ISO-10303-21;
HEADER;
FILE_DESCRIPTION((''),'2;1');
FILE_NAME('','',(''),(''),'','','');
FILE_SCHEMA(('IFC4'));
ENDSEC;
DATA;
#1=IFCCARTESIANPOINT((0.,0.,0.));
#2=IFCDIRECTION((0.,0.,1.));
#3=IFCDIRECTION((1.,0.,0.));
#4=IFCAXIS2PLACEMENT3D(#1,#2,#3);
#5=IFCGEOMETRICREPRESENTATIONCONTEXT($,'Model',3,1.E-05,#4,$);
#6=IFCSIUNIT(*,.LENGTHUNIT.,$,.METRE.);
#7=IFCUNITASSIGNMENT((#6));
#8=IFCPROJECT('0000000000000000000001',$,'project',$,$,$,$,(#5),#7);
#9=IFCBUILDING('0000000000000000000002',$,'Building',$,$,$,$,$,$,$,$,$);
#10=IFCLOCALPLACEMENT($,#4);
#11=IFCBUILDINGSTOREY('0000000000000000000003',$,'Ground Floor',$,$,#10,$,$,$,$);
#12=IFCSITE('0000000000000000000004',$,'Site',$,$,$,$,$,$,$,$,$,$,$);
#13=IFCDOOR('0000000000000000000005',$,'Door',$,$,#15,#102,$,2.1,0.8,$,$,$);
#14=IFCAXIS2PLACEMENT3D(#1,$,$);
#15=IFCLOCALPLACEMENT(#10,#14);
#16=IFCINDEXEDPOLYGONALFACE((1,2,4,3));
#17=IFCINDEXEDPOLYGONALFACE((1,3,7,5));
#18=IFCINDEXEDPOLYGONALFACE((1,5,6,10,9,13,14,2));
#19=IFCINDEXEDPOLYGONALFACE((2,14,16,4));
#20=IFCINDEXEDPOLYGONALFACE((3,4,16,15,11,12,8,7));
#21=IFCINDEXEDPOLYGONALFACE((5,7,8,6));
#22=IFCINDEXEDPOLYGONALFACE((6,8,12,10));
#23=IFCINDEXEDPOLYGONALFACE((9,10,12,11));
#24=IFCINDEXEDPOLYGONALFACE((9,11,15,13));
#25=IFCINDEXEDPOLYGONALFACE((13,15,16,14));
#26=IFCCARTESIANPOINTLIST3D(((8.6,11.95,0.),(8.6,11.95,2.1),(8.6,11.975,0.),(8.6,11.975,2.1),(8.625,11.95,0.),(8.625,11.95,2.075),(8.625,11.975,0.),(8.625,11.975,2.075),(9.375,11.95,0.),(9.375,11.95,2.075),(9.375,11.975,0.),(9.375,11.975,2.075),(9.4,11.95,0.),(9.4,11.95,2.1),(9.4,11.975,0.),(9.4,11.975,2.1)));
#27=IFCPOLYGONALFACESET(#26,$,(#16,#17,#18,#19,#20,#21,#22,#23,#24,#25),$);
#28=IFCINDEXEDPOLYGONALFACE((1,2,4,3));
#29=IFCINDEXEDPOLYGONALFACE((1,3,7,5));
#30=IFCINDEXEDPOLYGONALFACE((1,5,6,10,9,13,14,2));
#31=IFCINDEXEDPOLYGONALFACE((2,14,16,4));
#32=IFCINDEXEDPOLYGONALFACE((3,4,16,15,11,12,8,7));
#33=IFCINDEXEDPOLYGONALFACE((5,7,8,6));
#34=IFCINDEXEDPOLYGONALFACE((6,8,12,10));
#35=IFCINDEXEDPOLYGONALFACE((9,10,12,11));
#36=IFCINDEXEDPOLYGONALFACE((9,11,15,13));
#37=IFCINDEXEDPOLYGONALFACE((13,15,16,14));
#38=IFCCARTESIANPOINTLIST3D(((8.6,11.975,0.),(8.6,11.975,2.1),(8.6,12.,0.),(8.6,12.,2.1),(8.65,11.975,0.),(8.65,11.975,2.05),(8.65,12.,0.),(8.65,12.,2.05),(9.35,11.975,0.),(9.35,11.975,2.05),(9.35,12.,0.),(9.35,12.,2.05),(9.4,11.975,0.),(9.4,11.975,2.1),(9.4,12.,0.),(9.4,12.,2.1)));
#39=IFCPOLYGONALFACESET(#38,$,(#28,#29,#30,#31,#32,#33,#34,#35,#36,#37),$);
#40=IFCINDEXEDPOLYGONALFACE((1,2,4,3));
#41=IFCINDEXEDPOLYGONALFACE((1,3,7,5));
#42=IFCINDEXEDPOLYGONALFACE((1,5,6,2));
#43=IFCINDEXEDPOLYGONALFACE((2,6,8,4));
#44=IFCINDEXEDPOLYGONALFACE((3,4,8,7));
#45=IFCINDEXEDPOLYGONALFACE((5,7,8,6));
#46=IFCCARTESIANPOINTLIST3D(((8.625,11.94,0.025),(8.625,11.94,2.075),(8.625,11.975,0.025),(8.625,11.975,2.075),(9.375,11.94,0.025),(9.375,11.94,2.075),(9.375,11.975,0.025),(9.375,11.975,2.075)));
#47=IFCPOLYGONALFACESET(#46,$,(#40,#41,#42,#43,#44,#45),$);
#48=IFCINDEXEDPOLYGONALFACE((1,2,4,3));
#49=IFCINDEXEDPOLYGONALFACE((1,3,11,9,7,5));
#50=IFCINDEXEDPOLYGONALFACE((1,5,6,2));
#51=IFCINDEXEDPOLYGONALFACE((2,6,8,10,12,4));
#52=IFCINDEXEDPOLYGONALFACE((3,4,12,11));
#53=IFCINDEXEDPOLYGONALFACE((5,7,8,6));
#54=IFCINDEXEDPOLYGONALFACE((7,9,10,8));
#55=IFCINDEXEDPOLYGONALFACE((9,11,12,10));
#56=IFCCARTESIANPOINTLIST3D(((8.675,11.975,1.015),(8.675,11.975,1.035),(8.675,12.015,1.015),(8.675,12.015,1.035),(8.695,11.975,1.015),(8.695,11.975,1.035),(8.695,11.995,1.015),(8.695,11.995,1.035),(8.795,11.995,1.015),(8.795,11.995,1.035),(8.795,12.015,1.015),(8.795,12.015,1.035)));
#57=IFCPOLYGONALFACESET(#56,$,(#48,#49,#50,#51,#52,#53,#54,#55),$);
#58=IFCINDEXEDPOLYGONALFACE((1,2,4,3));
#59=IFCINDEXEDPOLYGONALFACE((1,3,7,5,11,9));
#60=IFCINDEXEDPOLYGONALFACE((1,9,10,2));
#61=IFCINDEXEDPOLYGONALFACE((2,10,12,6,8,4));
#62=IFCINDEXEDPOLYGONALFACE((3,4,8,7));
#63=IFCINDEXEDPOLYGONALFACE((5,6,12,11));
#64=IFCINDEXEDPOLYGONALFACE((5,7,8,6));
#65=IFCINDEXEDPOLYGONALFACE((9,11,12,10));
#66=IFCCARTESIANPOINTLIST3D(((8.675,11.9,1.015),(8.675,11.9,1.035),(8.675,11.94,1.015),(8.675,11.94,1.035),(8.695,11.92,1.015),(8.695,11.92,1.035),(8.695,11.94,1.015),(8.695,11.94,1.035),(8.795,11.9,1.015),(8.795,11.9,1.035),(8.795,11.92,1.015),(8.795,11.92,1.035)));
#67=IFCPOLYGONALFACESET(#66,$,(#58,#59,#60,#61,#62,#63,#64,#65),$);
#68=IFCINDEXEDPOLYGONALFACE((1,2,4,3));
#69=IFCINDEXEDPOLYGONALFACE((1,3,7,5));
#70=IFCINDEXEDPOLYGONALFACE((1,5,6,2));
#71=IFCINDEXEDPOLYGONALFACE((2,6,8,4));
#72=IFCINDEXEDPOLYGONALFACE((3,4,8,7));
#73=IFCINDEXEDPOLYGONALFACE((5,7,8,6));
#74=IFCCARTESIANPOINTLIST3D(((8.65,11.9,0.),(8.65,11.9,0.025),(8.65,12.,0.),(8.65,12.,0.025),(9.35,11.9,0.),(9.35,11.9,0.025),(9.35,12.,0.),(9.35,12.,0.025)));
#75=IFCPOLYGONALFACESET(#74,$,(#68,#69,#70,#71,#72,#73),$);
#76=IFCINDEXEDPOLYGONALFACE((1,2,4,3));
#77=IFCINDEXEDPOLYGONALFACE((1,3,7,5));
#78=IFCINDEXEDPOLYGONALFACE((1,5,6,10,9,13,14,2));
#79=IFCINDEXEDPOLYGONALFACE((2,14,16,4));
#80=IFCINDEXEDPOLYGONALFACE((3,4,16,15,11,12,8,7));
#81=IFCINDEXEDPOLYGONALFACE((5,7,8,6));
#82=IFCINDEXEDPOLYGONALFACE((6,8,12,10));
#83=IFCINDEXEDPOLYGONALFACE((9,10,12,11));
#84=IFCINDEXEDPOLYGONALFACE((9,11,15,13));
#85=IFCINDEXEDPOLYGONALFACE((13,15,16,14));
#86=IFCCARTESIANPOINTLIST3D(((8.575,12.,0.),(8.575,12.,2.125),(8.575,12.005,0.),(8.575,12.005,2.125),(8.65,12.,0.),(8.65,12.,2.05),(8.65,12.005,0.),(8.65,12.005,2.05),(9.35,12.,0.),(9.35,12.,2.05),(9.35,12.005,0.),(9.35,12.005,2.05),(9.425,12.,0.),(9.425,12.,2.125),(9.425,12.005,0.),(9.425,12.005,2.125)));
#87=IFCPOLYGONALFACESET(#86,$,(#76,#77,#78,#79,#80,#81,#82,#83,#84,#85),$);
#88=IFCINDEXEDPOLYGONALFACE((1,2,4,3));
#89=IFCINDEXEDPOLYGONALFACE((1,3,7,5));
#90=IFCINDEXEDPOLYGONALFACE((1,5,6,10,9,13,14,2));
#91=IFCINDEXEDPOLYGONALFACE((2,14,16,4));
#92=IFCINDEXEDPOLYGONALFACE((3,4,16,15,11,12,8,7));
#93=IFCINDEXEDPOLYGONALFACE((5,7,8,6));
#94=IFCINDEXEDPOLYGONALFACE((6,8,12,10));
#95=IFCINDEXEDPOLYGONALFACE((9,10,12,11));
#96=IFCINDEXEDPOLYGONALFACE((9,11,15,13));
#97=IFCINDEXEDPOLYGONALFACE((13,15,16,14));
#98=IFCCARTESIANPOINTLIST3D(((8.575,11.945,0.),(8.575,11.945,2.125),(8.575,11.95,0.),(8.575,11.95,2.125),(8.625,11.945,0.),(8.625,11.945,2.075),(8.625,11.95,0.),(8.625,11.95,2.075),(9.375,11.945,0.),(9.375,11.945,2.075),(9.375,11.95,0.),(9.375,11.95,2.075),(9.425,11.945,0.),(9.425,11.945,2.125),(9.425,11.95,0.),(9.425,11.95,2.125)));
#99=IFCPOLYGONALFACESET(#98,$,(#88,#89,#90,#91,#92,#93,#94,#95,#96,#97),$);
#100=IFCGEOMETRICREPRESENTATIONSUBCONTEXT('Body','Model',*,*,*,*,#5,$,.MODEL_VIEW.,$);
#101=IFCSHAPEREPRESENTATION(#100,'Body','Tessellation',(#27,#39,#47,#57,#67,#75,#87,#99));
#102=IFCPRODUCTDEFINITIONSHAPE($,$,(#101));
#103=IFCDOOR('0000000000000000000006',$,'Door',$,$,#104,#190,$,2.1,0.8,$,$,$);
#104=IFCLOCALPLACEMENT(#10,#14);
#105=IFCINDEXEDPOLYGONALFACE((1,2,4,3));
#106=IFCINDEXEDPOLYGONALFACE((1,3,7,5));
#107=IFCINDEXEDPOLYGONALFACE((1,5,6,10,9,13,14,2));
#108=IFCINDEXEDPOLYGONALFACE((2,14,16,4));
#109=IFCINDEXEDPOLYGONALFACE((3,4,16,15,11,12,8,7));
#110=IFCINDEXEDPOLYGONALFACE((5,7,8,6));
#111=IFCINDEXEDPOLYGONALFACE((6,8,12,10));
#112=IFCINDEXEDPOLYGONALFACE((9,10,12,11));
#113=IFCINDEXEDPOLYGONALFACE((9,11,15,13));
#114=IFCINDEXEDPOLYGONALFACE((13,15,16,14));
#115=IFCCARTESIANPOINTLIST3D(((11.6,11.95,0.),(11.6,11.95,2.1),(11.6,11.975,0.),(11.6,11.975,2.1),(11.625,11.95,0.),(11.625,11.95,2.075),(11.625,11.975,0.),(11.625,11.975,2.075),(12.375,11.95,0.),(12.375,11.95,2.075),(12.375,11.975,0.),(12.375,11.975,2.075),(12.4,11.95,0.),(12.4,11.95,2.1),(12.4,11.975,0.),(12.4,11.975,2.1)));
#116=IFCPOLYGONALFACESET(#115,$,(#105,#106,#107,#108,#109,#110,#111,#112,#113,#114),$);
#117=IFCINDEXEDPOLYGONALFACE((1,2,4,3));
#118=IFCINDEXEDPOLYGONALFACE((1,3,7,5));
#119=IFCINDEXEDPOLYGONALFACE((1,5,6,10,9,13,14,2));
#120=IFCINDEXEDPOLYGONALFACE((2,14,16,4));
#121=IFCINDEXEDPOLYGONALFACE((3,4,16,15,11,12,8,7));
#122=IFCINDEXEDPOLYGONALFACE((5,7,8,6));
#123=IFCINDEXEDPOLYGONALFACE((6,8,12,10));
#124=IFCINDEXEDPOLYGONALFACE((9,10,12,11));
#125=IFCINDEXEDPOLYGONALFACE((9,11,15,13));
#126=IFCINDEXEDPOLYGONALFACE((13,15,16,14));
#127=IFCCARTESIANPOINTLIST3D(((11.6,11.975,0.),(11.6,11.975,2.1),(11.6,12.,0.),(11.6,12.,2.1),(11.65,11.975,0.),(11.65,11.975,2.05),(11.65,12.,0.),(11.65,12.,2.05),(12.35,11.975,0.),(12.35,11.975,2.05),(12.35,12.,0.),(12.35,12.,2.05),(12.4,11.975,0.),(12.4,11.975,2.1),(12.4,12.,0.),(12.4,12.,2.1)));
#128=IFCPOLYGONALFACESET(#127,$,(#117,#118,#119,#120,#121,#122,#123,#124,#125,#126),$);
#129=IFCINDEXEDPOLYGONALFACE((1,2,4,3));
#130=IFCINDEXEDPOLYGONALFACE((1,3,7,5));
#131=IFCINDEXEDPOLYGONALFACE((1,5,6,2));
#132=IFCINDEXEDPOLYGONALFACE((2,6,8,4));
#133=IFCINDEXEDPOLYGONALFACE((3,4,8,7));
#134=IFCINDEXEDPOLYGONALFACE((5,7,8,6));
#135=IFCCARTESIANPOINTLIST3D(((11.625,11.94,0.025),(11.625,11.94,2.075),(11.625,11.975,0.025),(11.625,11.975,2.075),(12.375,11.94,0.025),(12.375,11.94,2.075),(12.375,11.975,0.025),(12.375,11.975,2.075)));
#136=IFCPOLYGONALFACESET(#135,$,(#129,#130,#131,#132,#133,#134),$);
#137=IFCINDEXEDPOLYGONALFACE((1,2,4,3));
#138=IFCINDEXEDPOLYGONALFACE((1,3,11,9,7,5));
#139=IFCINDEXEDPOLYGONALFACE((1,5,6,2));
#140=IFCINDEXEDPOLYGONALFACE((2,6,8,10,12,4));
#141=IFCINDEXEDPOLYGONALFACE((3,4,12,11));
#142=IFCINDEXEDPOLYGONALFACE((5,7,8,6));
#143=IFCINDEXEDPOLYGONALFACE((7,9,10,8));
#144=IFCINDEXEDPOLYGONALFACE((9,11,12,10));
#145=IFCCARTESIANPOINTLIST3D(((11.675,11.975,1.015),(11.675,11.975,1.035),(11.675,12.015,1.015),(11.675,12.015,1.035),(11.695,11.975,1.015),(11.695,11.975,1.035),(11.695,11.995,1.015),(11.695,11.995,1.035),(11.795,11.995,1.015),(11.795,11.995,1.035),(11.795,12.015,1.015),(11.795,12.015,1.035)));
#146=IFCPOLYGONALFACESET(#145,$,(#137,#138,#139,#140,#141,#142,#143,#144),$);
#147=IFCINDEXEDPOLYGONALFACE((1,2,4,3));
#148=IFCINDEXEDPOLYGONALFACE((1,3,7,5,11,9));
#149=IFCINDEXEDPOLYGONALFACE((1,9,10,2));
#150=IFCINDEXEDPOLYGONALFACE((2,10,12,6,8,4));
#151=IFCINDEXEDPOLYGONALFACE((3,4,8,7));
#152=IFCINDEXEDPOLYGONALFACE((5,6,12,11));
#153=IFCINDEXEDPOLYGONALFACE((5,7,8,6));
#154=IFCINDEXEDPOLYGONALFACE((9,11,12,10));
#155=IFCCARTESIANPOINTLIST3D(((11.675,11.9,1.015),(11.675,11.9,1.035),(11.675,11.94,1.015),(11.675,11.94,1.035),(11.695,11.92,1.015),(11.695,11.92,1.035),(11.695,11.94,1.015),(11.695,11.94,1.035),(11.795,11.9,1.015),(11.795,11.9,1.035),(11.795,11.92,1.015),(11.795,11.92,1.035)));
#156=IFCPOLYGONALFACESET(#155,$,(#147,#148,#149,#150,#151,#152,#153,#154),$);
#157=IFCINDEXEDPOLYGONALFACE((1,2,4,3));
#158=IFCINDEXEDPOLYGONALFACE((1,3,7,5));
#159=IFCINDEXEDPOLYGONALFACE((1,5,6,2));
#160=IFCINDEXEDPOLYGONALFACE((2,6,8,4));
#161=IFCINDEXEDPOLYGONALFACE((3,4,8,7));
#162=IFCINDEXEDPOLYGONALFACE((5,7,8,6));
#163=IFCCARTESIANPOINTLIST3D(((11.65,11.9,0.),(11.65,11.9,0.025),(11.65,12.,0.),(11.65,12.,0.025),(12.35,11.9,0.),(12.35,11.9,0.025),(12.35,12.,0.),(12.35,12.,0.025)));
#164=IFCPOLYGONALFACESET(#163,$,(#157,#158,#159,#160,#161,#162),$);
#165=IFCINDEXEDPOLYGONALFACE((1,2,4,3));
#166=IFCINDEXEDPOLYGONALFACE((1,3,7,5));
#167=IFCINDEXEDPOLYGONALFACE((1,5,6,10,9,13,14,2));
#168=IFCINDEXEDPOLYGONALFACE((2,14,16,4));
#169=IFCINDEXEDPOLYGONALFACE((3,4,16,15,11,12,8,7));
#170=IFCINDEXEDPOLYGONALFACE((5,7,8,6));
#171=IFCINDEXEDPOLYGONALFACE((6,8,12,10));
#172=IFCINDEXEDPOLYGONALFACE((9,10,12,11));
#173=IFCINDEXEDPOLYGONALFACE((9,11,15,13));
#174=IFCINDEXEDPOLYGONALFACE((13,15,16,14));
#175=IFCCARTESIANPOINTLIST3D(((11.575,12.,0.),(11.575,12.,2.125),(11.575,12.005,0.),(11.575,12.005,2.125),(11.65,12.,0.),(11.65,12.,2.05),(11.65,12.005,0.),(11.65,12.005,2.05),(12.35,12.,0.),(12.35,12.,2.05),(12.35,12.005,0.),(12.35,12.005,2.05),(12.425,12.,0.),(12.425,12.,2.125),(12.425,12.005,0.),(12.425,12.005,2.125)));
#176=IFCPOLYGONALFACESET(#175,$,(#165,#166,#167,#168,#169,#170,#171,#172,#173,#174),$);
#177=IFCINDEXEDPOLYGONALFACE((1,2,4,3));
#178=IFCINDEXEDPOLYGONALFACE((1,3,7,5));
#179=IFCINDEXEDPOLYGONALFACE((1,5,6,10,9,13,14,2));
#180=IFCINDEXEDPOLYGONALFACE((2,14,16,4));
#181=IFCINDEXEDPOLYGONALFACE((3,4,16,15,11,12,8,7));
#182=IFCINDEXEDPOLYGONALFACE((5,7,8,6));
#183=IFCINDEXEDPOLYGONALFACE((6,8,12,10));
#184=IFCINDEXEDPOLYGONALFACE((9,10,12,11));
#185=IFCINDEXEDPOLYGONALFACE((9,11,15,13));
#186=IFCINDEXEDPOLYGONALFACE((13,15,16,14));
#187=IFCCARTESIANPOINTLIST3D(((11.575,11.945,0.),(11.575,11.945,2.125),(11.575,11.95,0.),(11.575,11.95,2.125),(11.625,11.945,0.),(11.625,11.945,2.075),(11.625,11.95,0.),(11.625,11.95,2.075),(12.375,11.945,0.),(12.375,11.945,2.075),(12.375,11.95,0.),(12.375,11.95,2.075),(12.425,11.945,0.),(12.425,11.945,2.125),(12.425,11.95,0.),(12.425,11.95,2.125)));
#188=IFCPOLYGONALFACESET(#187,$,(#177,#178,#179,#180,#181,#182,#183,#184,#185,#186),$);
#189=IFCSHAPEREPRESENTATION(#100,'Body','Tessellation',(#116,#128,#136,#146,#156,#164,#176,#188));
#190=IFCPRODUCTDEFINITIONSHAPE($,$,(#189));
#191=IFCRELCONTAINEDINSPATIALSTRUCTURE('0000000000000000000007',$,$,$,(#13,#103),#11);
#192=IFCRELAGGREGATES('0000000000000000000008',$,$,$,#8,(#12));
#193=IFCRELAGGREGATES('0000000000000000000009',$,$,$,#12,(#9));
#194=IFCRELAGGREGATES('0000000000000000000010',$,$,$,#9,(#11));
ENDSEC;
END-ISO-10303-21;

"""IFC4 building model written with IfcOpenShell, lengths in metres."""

from ifc_helpers import new_model, si_unit, frame, origin_with_axes, place, context, subcontext, project, spatial, line, indexed_curve, outline, extrude, element, save


model = new_model("IFC4")

# Units and contexts
model_context = context("Model", 3, precision=1e-05, world=origin_with_axes())
body_context = subcontext(model_context, "Body", "Model", "MODEL_VIEW")
ifc_project = project(units=[si_unit("LENGTHUNIT", "METRE")], contexts=[model_context])

# Site, building, storey
site = spatial("IfcSite", under=ifc_project, Name="Site")
building = spatial("IfcBuilding", under=site, Name="Building")
storey_placement = place(None, origin_with_axes())
storey = spatial("IfcBuildingStorey", under=building, at=storey_placement, Name="Ground Floor")

# Doors
door_1_placement = place(storey_placement, frame((9.4, 12.0, 0.0), z_axis=(0.0, 0.0, 1.0), x_axis=(-1.0, 0.0, 0.0)))
element("IfcDoor", 1, at=door_1_placement, inside=storey, Name="Door", OverallHeight=2.1, OverallWidth=0.8, context=body_context, shape_type="SweptSolid", body=[
    extrude(outline(indexed_curve([(0.0, 0.0), (0.0, 2.1), (0.8, 2.1), (0.8, 0.0), (0.775, 0.0), (0.775, 2.075), (0.025, 2.075), (0.025, 0.0)], segments=[line(1, 2, 3, 4, 5, 6, 7, 8, 1)])), frame((0.0, 0.025, 0.0), z_axis=(0.0, -1.0, 0.0), x_axis=(1.0, 0.0, 0.0)), (0.0, 0.0, -1.0), 0.025),
    extrude(outline(indexed_curve([(0.0, 0.0), (0.0, 2.1), (0.8, 2.1), (0.8, 0.0), (0.75, 0.0), (0.75, 2.05), (0.05, 2.05), (0.05, 0.0)], segments=[line(1, 2, 3, 4, 5, 6, 7, 8, 1)])), frame((0.0, 0.0, 0.0), z_axis=(0.0, -1.0, 0.0), x_axis=(1.0, 0.0, 0.0)), (0.0, 0.0, -1.0), 0.025),
    extrude(outline(indexed_curve([(0.0, 0.0), (0.75, 0.0), (0.75, 0.035), (0.0, 0.035)], segments=[line(1, 2, 3, 4, 1)])), frame((0.025, 0.025, 0.025), z_axis=(0.0, 0.0, 1.0), x_axis=(1.0, 0.0, 0.0)), (0.0, 0.0, 1.0), 2.05),
    extrude(outline(indexed_curve([(0.0, 0.0), (0.0, -0.04), (-0.12, -0.04), (-0.12, -0.02), (-0.02, -0.02), (-0.02, 0.0)], segments=[line(1, 2, 3, 4, 5, 6, 1)])), frame((0.725, 0.025, 1.015), z_axis=(0.0, 0.0, 1.0), x_axis=(1.0, 0.0, 0.0)), (0.0, 0.0, 1.0), 0.02),
    extrude(outline(indexed_curve([(0.0, 0.0), (0.0, 0.04), (-0.12, 0.04), (-0.12, 0.02), (-0.02, 0.02), (-0.02, 0.0)], segments=[line(1, 2, 3, 4, 5, 6, 1)])), frame((0.725, 0.06, 1.015), z_axis=(0.0, 0.0, 1.0), x_axis=(1.0, 0.0, 0.0)), (0.0, 0.0, 1.0), 0.02),
    extrude(outline(indexed_curve([(0.0, 0.0), (0.7, 0.0), (0.7, 0.1), (0.0, 0.1)], segments=[line(1, 2, 3, 4, 1)])), frame((0.05, 0.0, 0.0), z_axis=(0.0, 0.0, 1.0), x_axis=(1.0, 0.0, 0.0)), (0.0, 0.0, 1.0), 0.025),
    extrude(outline(indexed_curve([(0.0, 0.0), (0.0, 2.125), (0.85, 2.125), (0.85, 0.0), (0.775, 0.0), (0.775, 2.05), (0.075, 2.05), (0.075, 0.0)], segments=[line(1, 2, 3, 4, 5, 6, 7, 8, 1)])), frame((-0.025, -0.005, 0.0), z_axis=(0.0, -1.0, 0.0), x_axis=(1.0, 0.0, 0.0)), (0.0, 0.0, -1.0), 0.005),
    extrude(outline(indexed_curve([(0.0, 0.0), (0.0, 2.125), (0.85, 2.125), (0.85, 0.0), (0.8, 0.0), (0.8, 2.075), (0.05, 2.075), (0.05, 0.0)], segments=[line(1, 2, 3, 4, 5, 6, 7, 8, 1)])), frame((-0.025, 0.05, 0.0), z_axis=(0.0, -1.0, 0.0), x_axis=(1.0, 0.0, 0.0)), (0.0, 0.0, -1.0), 0.005),
])
door_2_placement = place(storey_placement, frame((12.4, 12.0, 0.0), z_axis=(0.0, 0.0, 1.0), x_axis=(-1.0, 0.0, 0.0)))
element("IfcDoor", 2, at=door_2_placement, inside=storey, Name="Door", OverallHeight=2.1, OverallWidth=0.8, context=body_context, shape_type="SweptSolid", body=[
    extrude(outline(indexed_curve([(0.0, 0.0), (0.0, 2.1), (0.8, 2.1), (0.8, 0.0), (0.775, 0.0), (0.775, 2.075), (0.025, 2.075), (0.025, 0.0)], segments=[line(1, 2, 3, 4, 5, 6, 7, 8, 1)])), frame((0.0, 0.025, 0.0), z_axis=(0.0, -1.0, 0.0), x_axis=(1.0, 0.0, 0.0)), (0.0, 0.0, -1.0), 0.025),
    extrude(outline(indexed_curve([(0.0, 0.0), (0.0, 2.1), (0.8, 2.1), (0.8, 0.0), (0.75, 0.0), (0.75, 2.05), (0.05, 2.05), (0.05, 0.0)], segments=[line(1, 2, 3, 4, 5, 6, 7, 8, 1)])), frame((0.0, 0.0, 0.0), z_axis=(0.0, -1.0, 0.0), x_axis=(1.0, 0.0, 0.0)), (0.0, 0.0, -1.0), 0.025),
    extrude(outline(indexed_curve([(0.0, 0.0), (0.75, 0.0), (0.75, 0.035), (0.0, 0.035)], segments=[line(1, 2, 3, 4, 1)])), frame((0.025, 0.025, 0.025), z_axis=(0.0, 0.0, 1.0), x_axis=(1.0, 0.0, 0.0)), (0.0, 0.0, 1.0), 2.05),
    extrude(outline(indexed_curve([(0.0, 0.0), (0.0, -0.04), (-0.12, -0.04), (-0.12, -0.02), (-0.02, -0.02), (-0.02, 0.0)], segments=[line(1, 2, 3, 4, 5, 6, 1)])), frame((0.725, 0.025, 1.015), z_axis=(0.0, 0.0, 1.0), x_axis=(1.0, 0.0, 0.0)), (0.0, 0.0, 1.0), 0.02),
    extrude(outline(indexed_curve([(0.0, 0.0), (0.0, 0.04), (-0.12, 0.04), (-0.12, 0.02), (-0.02, 0.02), (-0.02, 0.0)], segments=[line(1, 2, 3, 4, 5, 6, 1)])), frame((0.725, 0.06, 1.015), z_axis=(0.0, 0.0, 1.0), x_axis=(1.0, 0.0, 0.0)), (0.0, 0.0, 1.0), 0.02),
    extrude(outline(indexed_curve([(0.0, 0.0), (0.7, 0.0), (0.7, 0.1), (0.0, 0.1)], segments=[line(1, 2, 3, 4, 1)])), frame((0.05, 0.0, 0.0), z_axis=(0.0, 0.0, 1.0), x_axis=(1.0, 0.0, 0.0)), (0.0, 0.0, 1.0), 0.025),
    extrude(outline(indexed_curve([(0.0, 0.0), (0.0, 2.125), (0.85, 2.125), (0.85, 0.0), (0.775, 0.0), (0.775, 2.05), (0.075, 2.05), (0.075, 0.0)], segments=[line(1, 2, 3, 4, 5, 6, 7, 8, 1)])), frame((-0.025, -0.005, 0.0), z_axis=(0.0, -1.0, 0.0), x_axis=(1.0, 0.0, 0.0)), (0.0, 0.0, -1.0), 0.005),
    extrude(outline(indexed_curve([(0.0, 0.0), (0.0, 2.125), (0.85, 2.125), (0.85, 0.0), (0.8, 0.0), (0.8, 2.075), (0.05, 2.075), (0.05, 0.0)], segments=[line(1, 2, 3, 4, 5, 6, 7, 8, 1)])), frame((-0.025, 0.05, 0.0), z_axis=(0.0, -1.0, 0.0), x_axis=(1.0, 0.0, 0.0)), (0.0, 0.0, -1.0), 0.005),
])

save(model, "model.ifc")
